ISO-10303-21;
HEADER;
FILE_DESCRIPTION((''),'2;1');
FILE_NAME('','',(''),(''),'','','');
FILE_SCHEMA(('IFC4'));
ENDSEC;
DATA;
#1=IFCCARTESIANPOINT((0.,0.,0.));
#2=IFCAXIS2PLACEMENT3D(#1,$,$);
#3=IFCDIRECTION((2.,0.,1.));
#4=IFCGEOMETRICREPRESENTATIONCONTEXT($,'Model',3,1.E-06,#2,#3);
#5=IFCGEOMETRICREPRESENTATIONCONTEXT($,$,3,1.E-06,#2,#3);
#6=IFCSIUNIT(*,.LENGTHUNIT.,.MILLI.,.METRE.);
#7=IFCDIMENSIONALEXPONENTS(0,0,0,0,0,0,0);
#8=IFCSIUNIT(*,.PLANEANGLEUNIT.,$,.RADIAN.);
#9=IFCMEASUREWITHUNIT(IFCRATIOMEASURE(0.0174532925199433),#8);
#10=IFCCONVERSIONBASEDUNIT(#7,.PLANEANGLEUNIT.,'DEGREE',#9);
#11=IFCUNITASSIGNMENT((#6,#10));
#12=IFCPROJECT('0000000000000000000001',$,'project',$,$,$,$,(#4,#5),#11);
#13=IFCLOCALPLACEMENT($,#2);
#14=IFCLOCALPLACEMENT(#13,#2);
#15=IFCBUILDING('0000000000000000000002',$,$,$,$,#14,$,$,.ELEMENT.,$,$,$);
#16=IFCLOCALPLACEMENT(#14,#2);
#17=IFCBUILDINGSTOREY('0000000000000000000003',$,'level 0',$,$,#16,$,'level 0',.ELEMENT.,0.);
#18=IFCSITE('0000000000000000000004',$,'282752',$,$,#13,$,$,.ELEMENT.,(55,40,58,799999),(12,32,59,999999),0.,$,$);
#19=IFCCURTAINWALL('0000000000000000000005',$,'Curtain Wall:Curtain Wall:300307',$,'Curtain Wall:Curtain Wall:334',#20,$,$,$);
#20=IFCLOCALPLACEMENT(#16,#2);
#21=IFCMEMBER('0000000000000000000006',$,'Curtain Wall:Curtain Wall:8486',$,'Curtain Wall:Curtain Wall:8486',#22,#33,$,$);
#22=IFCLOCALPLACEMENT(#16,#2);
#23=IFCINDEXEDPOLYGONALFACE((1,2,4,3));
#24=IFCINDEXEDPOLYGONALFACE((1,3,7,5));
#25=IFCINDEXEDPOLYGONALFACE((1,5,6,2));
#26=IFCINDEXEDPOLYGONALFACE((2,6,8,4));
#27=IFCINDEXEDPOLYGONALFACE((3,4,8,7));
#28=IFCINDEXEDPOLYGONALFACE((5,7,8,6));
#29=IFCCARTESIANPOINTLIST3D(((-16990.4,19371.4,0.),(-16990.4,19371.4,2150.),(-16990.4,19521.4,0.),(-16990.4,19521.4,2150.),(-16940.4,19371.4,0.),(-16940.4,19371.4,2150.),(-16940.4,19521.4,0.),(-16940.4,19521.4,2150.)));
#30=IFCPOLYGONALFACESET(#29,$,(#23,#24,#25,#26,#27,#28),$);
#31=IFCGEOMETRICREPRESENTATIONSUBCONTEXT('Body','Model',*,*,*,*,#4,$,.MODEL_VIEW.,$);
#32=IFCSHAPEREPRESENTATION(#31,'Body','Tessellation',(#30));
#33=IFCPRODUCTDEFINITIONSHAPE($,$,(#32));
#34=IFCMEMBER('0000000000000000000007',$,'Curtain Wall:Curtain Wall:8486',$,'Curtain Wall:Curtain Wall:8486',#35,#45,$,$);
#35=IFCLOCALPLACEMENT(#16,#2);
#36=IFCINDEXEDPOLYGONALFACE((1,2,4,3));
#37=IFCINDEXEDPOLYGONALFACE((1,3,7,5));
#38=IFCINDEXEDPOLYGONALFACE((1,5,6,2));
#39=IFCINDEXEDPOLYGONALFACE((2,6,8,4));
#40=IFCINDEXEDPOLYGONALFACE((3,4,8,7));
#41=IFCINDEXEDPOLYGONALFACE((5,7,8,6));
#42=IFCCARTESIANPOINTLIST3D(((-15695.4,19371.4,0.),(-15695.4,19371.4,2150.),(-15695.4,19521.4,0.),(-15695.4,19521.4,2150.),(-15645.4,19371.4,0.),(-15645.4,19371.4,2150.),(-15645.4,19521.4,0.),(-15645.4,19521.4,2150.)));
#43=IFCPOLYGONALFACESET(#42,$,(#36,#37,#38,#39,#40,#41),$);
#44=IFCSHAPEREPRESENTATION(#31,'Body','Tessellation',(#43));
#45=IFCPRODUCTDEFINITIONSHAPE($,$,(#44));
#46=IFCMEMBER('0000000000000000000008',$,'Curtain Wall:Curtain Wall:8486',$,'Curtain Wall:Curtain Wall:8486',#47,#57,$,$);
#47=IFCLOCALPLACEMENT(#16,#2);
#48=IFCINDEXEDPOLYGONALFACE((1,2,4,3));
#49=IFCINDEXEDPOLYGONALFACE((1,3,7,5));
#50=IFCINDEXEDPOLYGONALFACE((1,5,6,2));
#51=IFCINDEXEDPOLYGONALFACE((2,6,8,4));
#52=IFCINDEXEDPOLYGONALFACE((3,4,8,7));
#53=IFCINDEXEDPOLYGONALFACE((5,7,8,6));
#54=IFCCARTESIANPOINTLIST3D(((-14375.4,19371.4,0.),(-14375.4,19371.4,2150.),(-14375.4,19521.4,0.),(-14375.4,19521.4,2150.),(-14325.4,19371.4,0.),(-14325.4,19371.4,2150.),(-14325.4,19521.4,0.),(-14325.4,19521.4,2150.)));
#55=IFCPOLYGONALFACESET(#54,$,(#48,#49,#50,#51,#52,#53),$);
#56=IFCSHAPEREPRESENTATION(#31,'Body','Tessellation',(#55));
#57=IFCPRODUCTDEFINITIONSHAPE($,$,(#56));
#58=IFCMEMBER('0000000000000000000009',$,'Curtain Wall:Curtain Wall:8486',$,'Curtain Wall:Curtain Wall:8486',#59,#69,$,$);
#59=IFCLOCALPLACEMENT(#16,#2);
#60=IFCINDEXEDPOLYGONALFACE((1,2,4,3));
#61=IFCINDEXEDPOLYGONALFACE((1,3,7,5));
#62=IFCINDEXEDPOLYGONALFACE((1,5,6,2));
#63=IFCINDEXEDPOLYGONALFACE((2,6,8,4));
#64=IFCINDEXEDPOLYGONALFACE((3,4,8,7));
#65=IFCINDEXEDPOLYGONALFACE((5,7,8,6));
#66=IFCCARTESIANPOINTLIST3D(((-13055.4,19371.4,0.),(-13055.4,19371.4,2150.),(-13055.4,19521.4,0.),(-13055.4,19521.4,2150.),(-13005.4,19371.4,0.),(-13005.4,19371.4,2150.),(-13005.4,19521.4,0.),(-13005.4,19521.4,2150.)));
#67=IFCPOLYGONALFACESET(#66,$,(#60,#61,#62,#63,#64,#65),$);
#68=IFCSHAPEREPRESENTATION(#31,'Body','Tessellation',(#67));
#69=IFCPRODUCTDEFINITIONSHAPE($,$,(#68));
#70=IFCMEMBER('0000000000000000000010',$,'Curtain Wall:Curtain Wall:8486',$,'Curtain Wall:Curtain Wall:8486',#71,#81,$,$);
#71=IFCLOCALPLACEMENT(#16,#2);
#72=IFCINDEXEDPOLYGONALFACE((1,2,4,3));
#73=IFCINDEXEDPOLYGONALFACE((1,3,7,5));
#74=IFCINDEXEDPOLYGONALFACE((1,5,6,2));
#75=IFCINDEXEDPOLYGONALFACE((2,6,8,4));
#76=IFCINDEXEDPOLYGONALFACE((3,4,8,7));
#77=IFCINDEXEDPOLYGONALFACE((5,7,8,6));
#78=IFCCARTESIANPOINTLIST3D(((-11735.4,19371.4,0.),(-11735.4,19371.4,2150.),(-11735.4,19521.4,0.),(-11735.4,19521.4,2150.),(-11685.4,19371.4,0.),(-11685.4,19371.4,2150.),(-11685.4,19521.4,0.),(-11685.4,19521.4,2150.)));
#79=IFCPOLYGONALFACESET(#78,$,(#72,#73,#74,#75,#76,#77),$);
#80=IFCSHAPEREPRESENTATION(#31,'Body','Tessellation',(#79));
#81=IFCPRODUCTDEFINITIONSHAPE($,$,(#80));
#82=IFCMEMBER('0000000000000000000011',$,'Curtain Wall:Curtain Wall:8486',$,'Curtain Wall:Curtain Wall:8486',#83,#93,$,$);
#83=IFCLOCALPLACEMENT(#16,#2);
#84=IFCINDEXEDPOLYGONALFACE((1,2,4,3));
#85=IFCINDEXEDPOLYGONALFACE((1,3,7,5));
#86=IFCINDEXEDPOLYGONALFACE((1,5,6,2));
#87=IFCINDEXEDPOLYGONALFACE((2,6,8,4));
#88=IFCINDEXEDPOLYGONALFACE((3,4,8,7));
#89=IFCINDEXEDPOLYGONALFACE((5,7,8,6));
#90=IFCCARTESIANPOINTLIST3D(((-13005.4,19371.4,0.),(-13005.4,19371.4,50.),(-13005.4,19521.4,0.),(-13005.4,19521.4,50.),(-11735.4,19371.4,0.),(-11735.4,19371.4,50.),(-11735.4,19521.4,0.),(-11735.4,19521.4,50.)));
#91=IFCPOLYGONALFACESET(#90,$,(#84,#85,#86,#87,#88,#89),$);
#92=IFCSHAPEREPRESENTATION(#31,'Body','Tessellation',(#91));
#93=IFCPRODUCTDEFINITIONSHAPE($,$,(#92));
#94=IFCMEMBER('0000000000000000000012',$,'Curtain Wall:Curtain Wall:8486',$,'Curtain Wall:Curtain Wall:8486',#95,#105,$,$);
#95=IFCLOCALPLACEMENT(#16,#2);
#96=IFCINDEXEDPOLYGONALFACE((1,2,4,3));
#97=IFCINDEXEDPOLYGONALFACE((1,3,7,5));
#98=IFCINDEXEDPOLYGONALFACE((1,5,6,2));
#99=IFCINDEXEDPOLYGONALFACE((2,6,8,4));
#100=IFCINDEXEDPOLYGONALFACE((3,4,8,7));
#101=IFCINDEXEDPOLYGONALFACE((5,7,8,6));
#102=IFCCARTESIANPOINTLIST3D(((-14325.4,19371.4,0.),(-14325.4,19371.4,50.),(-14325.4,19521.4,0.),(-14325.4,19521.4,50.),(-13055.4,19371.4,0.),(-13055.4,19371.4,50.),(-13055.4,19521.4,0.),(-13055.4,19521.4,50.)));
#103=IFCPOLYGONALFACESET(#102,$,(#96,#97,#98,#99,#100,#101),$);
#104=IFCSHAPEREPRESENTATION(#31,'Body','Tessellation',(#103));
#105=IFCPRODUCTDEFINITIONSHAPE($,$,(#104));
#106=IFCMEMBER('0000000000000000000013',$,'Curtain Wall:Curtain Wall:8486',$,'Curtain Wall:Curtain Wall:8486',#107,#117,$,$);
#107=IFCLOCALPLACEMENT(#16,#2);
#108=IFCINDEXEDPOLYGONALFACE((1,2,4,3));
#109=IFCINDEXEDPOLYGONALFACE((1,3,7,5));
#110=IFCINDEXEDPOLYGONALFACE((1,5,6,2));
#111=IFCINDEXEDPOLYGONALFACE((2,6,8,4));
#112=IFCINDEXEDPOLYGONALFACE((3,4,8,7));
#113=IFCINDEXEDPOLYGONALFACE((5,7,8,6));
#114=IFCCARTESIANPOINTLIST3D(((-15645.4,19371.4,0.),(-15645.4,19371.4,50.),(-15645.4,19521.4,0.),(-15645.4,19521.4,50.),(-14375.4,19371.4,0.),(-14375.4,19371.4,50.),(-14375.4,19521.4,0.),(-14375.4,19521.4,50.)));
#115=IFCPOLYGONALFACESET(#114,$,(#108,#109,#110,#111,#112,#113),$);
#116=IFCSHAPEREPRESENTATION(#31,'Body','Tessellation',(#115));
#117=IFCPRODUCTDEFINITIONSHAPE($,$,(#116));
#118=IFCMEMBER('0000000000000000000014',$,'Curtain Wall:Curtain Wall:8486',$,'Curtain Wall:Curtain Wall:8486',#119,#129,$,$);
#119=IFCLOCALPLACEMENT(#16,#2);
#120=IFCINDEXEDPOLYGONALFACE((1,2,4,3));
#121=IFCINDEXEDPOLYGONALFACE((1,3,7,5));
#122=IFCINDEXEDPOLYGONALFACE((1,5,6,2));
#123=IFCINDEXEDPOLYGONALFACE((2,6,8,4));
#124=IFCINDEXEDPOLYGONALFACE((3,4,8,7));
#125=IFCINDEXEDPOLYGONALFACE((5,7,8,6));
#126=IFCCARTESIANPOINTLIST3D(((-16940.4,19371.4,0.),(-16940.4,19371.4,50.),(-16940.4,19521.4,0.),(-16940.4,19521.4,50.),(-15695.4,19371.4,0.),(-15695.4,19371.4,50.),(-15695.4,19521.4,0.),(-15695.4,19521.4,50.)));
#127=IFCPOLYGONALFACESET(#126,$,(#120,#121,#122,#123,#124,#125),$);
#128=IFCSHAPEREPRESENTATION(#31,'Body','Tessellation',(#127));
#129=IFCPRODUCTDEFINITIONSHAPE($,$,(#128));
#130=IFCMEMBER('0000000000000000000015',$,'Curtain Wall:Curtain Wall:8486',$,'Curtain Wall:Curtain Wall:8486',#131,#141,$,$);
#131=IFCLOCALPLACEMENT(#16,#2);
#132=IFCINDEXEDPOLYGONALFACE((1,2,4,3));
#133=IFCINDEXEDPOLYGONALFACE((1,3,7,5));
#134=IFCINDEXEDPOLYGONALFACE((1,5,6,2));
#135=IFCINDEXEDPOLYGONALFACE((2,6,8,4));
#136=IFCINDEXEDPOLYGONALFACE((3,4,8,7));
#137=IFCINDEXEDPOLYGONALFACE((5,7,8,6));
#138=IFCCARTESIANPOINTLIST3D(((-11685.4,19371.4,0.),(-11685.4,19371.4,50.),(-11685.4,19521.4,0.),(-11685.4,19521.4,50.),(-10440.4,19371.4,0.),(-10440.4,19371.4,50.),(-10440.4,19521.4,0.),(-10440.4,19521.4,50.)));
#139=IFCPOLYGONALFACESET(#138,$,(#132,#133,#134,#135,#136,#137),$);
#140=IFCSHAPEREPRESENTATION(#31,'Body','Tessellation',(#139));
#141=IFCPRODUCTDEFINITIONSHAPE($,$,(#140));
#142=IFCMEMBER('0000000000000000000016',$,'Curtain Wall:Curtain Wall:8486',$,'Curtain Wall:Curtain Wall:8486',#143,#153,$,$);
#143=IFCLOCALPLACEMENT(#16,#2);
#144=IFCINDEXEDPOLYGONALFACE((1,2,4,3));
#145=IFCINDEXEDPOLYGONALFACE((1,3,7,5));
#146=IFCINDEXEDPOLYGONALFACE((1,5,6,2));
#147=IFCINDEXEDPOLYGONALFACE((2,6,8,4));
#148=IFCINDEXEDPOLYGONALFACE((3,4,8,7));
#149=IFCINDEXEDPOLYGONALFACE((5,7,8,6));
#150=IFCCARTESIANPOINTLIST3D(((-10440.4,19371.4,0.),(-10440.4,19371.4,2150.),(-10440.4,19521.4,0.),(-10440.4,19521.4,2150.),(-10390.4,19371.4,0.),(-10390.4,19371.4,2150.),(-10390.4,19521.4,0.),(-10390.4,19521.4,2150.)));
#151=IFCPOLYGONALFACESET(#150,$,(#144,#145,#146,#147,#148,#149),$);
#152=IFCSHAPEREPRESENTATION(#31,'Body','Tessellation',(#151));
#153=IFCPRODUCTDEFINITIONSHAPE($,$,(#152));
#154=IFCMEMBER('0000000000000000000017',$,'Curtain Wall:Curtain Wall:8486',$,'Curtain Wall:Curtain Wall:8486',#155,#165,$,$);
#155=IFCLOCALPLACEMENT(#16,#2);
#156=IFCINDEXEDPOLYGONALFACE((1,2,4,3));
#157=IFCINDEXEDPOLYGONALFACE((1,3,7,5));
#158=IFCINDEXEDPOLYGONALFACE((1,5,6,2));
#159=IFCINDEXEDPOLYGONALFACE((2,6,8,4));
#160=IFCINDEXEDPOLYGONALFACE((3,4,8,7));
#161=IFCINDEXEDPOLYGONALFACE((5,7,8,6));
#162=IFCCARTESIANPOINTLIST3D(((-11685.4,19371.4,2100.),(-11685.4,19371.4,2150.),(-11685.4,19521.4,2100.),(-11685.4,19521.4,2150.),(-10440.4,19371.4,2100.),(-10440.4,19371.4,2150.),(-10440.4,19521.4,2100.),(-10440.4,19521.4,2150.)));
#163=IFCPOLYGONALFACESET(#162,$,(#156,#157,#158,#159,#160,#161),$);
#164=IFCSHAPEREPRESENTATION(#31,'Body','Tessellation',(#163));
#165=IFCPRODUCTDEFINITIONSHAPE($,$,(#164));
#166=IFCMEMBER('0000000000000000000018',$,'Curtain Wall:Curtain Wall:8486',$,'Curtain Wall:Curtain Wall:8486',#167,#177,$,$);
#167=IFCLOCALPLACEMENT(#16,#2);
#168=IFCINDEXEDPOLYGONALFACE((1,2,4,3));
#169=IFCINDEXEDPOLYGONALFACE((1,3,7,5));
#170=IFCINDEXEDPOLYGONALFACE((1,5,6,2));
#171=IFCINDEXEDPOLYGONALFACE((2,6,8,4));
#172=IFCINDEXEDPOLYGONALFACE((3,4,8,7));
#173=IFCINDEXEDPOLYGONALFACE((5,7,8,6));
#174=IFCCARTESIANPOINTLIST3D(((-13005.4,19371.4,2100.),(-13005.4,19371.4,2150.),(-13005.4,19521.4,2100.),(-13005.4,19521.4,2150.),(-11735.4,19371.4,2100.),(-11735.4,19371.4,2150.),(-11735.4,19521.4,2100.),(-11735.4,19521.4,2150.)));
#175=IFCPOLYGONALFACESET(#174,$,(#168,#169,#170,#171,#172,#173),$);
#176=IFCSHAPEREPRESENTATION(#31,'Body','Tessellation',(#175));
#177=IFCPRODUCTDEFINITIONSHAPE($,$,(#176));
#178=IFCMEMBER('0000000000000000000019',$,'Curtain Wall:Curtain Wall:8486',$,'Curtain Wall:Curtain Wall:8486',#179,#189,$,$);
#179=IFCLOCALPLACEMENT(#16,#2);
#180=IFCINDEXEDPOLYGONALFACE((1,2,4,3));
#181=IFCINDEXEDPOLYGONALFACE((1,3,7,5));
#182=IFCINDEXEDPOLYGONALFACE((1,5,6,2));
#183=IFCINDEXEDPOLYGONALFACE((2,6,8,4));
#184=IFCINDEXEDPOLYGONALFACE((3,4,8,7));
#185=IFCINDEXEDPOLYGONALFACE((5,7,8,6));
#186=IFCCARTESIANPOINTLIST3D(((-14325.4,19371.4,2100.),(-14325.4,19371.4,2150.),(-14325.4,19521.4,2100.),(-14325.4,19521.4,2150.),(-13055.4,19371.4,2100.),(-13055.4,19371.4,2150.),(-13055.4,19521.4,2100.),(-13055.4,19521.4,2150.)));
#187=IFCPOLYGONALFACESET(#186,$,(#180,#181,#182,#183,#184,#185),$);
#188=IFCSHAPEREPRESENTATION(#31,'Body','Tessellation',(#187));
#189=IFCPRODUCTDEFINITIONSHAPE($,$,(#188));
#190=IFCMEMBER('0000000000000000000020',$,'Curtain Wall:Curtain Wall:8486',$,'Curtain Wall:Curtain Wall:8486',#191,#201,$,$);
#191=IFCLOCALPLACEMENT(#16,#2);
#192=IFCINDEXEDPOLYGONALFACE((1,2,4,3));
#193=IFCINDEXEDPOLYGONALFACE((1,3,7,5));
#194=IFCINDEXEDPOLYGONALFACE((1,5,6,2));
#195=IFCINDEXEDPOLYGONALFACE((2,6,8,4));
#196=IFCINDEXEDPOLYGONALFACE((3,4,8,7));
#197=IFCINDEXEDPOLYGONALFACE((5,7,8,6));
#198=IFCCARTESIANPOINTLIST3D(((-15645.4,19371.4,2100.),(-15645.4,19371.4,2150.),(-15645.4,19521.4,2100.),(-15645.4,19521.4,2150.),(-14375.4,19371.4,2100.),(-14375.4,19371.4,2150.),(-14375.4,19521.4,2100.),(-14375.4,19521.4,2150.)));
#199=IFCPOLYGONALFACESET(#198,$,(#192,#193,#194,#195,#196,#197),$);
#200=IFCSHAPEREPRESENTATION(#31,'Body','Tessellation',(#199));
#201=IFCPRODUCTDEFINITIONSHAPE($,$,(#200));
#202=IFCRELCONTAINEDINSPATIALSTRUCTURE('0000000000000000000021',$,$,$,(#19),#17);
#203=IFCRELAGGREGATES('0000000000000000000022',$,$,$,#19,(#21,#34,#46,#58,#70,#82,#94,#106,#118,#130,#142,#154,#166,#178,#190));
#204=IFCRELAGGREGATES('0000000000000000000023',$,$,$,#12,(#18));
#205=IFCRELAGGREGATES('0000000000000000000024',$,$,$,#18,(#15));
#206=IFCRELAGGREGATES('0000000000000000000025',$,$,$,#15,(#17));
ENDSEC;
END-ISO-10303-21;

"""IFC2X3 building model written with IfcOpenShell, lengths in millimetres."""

from ifc_helpers import new_model, entity, si_unit, converted_unit, direction, frame, frame_2d, origin, origin_2d_with_axis, place, context, subcontext, project, spatial, rectangle, extrude, element, aggregate, save


model = new_model("IFC2X3")

# Units and contexts
model_context = context("Model", 3, precision=1e-06, world=origin(), true_north=direction((2.0, 0.0, 1.0)))
context_of_model = context(None, 3, precision=1e-06, world=origin(), true_north=direction((2.0, 0.0, 1.0)))
body_context = subcontext(model_context, "Body", "Model", "MODEL_VIEW")
ifc_project = project(units=[si_unit("LENGTHUNIT", "METRE", prefix="MILLI"), converted_unit("PLANEANGLEUNIT", "DEGREE", entity("IfcRatioMeasure", 0.0174532925199433), si_unit("PLANEANGLEUNIT", "RADIAN"), dimensions=[0, 0, 0, 0, 0, 0, 0])], contexts=[model_context, context_of_model])

# Site, building, storey
site_placement = place(None, origin())
site = spatial("IfcSite", under=ifc_project, at=site_placement, Name="282752", CompositionType="ELEMENT", RefLatitude=(55, 40, 58, 799999), RefLongitude=(12, 32, 59, 999999), RefElevation=0.0)
building_placement = place(site_placement, origin())
building = spatial("IfcBuilding", under=site, at=building_placement, CompositionType="ELEMENT")
storey_placement = place(building_placement, origin())
storey = spatial("IfcBuildingStorey", under=building, at=storey_placement, Name="level 0", LongName="level 0", CompositionType="ELEMENT", Elevation=0.0)

# Curtain wall, members
curtain_wall_placement = place(storey_placement, origin())
curtain_wall = element("IfcCurtainWall", 1, at=curtain_wall_placement, inside=storey, Name="Curtain Wall:Curtain Wall:300307", ObjectType="Curtain Wall:Curtain Wall:334")
member_1_placement = place(storey_placement, origin())
member_1 = element("IfcMember", 2, at=member_1_placement, Name="Curtain Wall:Curtain Wall:8486", ObjectType="Curtain Wall:Curtain Wall:8486", context=body_context, shape_type="SweptSolid", body=[
    extrude(rectangle(XDim=150.0, YDim=50.0, at=frame_2d((0.0, 0.0), x_axis=(1.0, 0.0))), frame((-16965.4, 19446.4, 0.0), z_axis=(0.0, 0.0, 1.0), x_axis=(0.0, -1.0, 0.0)), (0.0, 0.0, 1.0), 2150.0),
])
member_2_placement = place(storey_placement, origin())
member_2 = element("IfcMember", 3, at=member_2_placement, Name="Curtain Wall:Curtain Wall:8486", ObjectType="Curtain Wall:Curtain Wall:8486", context=body_context, shape_type="SweptSolid", body=[
    extrude(rectangle(XDim=150.0, YDim=50.0, at=origin_2d_with_axis()), frame((-15670.4, 19446.4, 0.0), z_axis=(0.0, 0.0, 1.0), x_axis=(0.0, -1.0, 0.0)), (0.0, 0.0, 1.0), 2150.0),
])
member_3_placement = place(storey_placement, origin())
member_3 = element("IfcMember", 4, at=member_3_placement, Name="Curtain Wall:Curtain Wall:8486", ObjectType="Curtain Wall:Curtain Wall:8486", context=body_context, shape_type="SweptSolid", body=[
    extrude(rectangle(XDim=150.0, YDim=50.0, at=origin_2d_with_axis()), frame((-14350.4, 19446.4, 0.0), z_axis=(0.0, 0.0, 1.0), x_axis=(0.0, -1.0, 0.0)), (0.0, 0.0, 1.0), 2150.0),
])
member_4_placement = place(storey_placement, origin())
member_4 = element("IfcMember", 5, at=member_4_placement, Name="Curtain Wall:Curtain Wall:8486", ObjectType="Curtain Wall:Curtain Wall:8486", context=body_context, shape_type="SweptSolid", body=[
    extrude(rectangle(XDim=150.0, YDim=50.0, at=origin_2d_with_axis()), frame((-13030.4, 19446.4, 0.0), z_axis=(0.0, 0.0, 1.0), x_axis=(0.0, -1.0, 0.0)), (0.0, 0.0, 1.0), 2150.0),
])
member_5_placement = place(storey_placement, origin())
member_5 = element("IfcMember", 6, at=member_5_placement, Name="Curtain Wall:Curtain Wall:8486", ObjectType="Curtain Wall:Curtain Wall:8486", context=body_context, shape_type="SweptSolid", body=[
    extrude(rectangle(XDim=150.0, YDim=50.0, at=origin_2d_with_axis()), frame((-11710.4, 19446.4, 0.0), z_axis=(0.0, 0.0, 1.0), x_axis=(0.0, -1.0, 0.0)), (0.0, 0.0, 1.0), 2150.0),
])
member_6_placement = place(storey_placement, origin())
member_6 = element("IfcMember", 7, at=member_6_placement, Name="Curtain Wall:Curtain Wall:8486", ObjectType="Curtain Wall:Curtain Wall:8486", context=body_context, shape_type="SweptSolid", body=[
    extrude(rectangle(XDim=1270.0, YDim=150.0, at=frame_2d((0.0, 0.0), x_axis=(1.0, 0.0))), frame((-12370.4, 19446.4, 0.0), z_axis=(0.0, 0.0, 1.0), x_axis=(-1.0, 0.0, 0.0)), (0.0, 0.0, 1.0), 50.0),
])
member_7_placement = place(storey_placement, origin())
member_7 = element("IfcMember", 8, at=member_7_placement, Name="Curtain Wall:Curtain Wall:8486", ObjectType="Curtain Wall:Curtain Wall:8486", context=body_context, shape_type="SweptSolid", body=[
    extrude(rectangle(XDim=1270.0, YDim=150.0, at=frame_2d((0.0, 0.0), x_axis=(1.0, 0.0))), frame((-13690.4, 19446.4, 0.0), z_axis=(0.0, 0.0, 1.0), x_axis=(-1.0, 0.0, 0.0)), (0.0, 0.0, 1.0), 50.0),
])
member_8_placement = place(storey_placement, origin())
member_8 = element("IfcMember", 9, at=member_8_placement, Name="Curtain Wall:Curtain Wall:8486", ObjectType="Curtain Wall:Curtain Wall:8486", context=body_context, shape_type="SweptSolid", body=[
    extrude(rectangle(XDim=1270.0, YDim=150.0, at=frame_2d((0.0, 0.0), x_axis=(1.0, 0.0))), frame((-15010.4, 19446.4, 0.0), z_axis=(0.0, 0.0, 1.0), x_axis=(-1.0, 0.0, 0.0)), (0.0, 0.0, 1.0), 50.0),
])
member_9_placement = place(storey_placement, origin())
member_9 = element("IfcMember", 10, at=member_9_placement, Name="Curtain Wall:Curtain Wall:8486", ObjectType="Curtain Wall:Curtain Wall:8486", context=body_context, shape_type="SweptSolid", body=[
    extrude(rectangle(XDim=1245.0, YDim=150.0, at=frame_2d((0.0, 0.0), x_axis=(1.0, 0.0))), frame((-16317.9, 19446.4, 0.0), z_axis=(0.0, 0.0, 1.0), x_axis=(-1.0, 0.0, 0.0)), (0.0, 0.0, 1.0), 50.0),
])
member_10_placement = place(storey_placement, origin())
member_10 = element("IfcMember", 11, at=member_10_placement, Name="Curtain Wall:Curtain Wall:8486", ObjectType="Curtain Wall:Curtain Wall:8486", context=body_context, shape_type="SweptSolid", body=[
    extrude(rectangle(XDim=1245.0, YDim=150.0, at=frame_2d((0.0, 0.0), x_axis=(1.0, 0.0))), frame((-11062.9, 19446.4, 0.0), z_axis=(0.0, 0.0, 1.0), x_axis=(-1.0, 0.0, 0.0)), (0.0, 0.0, 1.0), 50.0),
])
member_11_placement = place(storey_placement, origin())
member_11 = element("IfcMember", 12, at=member_11_placement, Name="Curtain Wall:Curtain Wall:8486", ObjectType="Curtain Wall:Curtain Wall:8486", context=body_context, shape_type="SweptSolid", body=[
    extrude(rectangle(XDim=50.0, YDim=150.0, at=frame_2d((0.0, 0.0), x_axis=(1.0, 0.0))), frame((-10415.4, 19446.4, 0.0), z_axis=(0.0, 0.0, 1.0), x_axis=(-1.0, 0.0, 0.0)), (0.0, 0.0, 1.0), 2150.0),
])
member_12_placement = place(storey_placement, origin())
member_12 = element("IfcMember", 13, at=member_12_placement, Name="Curtain Wall:Curtain Wall:8486", ObjectType="Curtain Wall:Curtain Wall:8486", context=body_context, shape_type="SweptSolid", body=[
    extrude(rectangle(XDim=1245.0, YDim=150.0, at=frame_2d((0.0, 0.0), x_axis=(1.0, 0.0))), frame((-11062.9, 19446.4, 2100.0)), (0.0, 0.0, 1.0), 50.0),
])
member_13_placement = place(storey_placement, origin())
member_13 = element("IfcMember", 14, at=member_13_placement, Name="Curtain Wall:Curtain Wall:8486", ObjectType="Curtain Wall:Curtain Wall:8486", context=body_context, shape_type="SweptSolid", body=[
    extrude(rectangle(XDim=1270.0, YDim=150.0, at=frame_2d((0.0, 0.0), x_axis=(1.0, 0.0))), frame((-12370.4, 19446.4, 2100.0)), (0.0, 0.0, 1.0), 50.0),
])
member_14_placement = place(storey_placement, origin())
member_14 = element("IfcMember", 15, at=member_14_placement, Name="Curtain Wall:Curtain Wall:8486", ObjectType="Curtain Wall:Curtain Wall:8486", context=body_context, shape_type="SweptSolid", body=[
    extrude(rectangle(XDim=1270.0, YDim=150.0, at=frame_2d((0.0, 0.0), x_axis=(1.0, 0.0))), frame((-13690.4, 19446.4, 2100.0)), (0.0, 0.0, 1.0), 50.0),
])
member_15_placement = place(storey_placement, origin())
member_15 = element("IfcMember", 16, at=member_15_placement, Name="Curtain Wall:Curtain Wall:8486", ObjectType="Curtain Wall:Curtain Wall:8486", context=body_context, shape_type="SweptSolid", body=[
    extrude(rectangle(XDim=1270.0, YDim=150.0, at=frame_2d((0.0, 0.0), x_axis=(1.0, 0.0))), frame((-15010.4, 19446.4, 2100.0)), (0.0, 0.0, 1.0), 50.0),
])
aggregate(curtain_wall, [member_1, member_2, member_3, member_4, member_5, member_6, member_7, member_8, member_9, member_10, member_11, member_12, member_13, member_14, member_15])

save(model, "model.ifc")
